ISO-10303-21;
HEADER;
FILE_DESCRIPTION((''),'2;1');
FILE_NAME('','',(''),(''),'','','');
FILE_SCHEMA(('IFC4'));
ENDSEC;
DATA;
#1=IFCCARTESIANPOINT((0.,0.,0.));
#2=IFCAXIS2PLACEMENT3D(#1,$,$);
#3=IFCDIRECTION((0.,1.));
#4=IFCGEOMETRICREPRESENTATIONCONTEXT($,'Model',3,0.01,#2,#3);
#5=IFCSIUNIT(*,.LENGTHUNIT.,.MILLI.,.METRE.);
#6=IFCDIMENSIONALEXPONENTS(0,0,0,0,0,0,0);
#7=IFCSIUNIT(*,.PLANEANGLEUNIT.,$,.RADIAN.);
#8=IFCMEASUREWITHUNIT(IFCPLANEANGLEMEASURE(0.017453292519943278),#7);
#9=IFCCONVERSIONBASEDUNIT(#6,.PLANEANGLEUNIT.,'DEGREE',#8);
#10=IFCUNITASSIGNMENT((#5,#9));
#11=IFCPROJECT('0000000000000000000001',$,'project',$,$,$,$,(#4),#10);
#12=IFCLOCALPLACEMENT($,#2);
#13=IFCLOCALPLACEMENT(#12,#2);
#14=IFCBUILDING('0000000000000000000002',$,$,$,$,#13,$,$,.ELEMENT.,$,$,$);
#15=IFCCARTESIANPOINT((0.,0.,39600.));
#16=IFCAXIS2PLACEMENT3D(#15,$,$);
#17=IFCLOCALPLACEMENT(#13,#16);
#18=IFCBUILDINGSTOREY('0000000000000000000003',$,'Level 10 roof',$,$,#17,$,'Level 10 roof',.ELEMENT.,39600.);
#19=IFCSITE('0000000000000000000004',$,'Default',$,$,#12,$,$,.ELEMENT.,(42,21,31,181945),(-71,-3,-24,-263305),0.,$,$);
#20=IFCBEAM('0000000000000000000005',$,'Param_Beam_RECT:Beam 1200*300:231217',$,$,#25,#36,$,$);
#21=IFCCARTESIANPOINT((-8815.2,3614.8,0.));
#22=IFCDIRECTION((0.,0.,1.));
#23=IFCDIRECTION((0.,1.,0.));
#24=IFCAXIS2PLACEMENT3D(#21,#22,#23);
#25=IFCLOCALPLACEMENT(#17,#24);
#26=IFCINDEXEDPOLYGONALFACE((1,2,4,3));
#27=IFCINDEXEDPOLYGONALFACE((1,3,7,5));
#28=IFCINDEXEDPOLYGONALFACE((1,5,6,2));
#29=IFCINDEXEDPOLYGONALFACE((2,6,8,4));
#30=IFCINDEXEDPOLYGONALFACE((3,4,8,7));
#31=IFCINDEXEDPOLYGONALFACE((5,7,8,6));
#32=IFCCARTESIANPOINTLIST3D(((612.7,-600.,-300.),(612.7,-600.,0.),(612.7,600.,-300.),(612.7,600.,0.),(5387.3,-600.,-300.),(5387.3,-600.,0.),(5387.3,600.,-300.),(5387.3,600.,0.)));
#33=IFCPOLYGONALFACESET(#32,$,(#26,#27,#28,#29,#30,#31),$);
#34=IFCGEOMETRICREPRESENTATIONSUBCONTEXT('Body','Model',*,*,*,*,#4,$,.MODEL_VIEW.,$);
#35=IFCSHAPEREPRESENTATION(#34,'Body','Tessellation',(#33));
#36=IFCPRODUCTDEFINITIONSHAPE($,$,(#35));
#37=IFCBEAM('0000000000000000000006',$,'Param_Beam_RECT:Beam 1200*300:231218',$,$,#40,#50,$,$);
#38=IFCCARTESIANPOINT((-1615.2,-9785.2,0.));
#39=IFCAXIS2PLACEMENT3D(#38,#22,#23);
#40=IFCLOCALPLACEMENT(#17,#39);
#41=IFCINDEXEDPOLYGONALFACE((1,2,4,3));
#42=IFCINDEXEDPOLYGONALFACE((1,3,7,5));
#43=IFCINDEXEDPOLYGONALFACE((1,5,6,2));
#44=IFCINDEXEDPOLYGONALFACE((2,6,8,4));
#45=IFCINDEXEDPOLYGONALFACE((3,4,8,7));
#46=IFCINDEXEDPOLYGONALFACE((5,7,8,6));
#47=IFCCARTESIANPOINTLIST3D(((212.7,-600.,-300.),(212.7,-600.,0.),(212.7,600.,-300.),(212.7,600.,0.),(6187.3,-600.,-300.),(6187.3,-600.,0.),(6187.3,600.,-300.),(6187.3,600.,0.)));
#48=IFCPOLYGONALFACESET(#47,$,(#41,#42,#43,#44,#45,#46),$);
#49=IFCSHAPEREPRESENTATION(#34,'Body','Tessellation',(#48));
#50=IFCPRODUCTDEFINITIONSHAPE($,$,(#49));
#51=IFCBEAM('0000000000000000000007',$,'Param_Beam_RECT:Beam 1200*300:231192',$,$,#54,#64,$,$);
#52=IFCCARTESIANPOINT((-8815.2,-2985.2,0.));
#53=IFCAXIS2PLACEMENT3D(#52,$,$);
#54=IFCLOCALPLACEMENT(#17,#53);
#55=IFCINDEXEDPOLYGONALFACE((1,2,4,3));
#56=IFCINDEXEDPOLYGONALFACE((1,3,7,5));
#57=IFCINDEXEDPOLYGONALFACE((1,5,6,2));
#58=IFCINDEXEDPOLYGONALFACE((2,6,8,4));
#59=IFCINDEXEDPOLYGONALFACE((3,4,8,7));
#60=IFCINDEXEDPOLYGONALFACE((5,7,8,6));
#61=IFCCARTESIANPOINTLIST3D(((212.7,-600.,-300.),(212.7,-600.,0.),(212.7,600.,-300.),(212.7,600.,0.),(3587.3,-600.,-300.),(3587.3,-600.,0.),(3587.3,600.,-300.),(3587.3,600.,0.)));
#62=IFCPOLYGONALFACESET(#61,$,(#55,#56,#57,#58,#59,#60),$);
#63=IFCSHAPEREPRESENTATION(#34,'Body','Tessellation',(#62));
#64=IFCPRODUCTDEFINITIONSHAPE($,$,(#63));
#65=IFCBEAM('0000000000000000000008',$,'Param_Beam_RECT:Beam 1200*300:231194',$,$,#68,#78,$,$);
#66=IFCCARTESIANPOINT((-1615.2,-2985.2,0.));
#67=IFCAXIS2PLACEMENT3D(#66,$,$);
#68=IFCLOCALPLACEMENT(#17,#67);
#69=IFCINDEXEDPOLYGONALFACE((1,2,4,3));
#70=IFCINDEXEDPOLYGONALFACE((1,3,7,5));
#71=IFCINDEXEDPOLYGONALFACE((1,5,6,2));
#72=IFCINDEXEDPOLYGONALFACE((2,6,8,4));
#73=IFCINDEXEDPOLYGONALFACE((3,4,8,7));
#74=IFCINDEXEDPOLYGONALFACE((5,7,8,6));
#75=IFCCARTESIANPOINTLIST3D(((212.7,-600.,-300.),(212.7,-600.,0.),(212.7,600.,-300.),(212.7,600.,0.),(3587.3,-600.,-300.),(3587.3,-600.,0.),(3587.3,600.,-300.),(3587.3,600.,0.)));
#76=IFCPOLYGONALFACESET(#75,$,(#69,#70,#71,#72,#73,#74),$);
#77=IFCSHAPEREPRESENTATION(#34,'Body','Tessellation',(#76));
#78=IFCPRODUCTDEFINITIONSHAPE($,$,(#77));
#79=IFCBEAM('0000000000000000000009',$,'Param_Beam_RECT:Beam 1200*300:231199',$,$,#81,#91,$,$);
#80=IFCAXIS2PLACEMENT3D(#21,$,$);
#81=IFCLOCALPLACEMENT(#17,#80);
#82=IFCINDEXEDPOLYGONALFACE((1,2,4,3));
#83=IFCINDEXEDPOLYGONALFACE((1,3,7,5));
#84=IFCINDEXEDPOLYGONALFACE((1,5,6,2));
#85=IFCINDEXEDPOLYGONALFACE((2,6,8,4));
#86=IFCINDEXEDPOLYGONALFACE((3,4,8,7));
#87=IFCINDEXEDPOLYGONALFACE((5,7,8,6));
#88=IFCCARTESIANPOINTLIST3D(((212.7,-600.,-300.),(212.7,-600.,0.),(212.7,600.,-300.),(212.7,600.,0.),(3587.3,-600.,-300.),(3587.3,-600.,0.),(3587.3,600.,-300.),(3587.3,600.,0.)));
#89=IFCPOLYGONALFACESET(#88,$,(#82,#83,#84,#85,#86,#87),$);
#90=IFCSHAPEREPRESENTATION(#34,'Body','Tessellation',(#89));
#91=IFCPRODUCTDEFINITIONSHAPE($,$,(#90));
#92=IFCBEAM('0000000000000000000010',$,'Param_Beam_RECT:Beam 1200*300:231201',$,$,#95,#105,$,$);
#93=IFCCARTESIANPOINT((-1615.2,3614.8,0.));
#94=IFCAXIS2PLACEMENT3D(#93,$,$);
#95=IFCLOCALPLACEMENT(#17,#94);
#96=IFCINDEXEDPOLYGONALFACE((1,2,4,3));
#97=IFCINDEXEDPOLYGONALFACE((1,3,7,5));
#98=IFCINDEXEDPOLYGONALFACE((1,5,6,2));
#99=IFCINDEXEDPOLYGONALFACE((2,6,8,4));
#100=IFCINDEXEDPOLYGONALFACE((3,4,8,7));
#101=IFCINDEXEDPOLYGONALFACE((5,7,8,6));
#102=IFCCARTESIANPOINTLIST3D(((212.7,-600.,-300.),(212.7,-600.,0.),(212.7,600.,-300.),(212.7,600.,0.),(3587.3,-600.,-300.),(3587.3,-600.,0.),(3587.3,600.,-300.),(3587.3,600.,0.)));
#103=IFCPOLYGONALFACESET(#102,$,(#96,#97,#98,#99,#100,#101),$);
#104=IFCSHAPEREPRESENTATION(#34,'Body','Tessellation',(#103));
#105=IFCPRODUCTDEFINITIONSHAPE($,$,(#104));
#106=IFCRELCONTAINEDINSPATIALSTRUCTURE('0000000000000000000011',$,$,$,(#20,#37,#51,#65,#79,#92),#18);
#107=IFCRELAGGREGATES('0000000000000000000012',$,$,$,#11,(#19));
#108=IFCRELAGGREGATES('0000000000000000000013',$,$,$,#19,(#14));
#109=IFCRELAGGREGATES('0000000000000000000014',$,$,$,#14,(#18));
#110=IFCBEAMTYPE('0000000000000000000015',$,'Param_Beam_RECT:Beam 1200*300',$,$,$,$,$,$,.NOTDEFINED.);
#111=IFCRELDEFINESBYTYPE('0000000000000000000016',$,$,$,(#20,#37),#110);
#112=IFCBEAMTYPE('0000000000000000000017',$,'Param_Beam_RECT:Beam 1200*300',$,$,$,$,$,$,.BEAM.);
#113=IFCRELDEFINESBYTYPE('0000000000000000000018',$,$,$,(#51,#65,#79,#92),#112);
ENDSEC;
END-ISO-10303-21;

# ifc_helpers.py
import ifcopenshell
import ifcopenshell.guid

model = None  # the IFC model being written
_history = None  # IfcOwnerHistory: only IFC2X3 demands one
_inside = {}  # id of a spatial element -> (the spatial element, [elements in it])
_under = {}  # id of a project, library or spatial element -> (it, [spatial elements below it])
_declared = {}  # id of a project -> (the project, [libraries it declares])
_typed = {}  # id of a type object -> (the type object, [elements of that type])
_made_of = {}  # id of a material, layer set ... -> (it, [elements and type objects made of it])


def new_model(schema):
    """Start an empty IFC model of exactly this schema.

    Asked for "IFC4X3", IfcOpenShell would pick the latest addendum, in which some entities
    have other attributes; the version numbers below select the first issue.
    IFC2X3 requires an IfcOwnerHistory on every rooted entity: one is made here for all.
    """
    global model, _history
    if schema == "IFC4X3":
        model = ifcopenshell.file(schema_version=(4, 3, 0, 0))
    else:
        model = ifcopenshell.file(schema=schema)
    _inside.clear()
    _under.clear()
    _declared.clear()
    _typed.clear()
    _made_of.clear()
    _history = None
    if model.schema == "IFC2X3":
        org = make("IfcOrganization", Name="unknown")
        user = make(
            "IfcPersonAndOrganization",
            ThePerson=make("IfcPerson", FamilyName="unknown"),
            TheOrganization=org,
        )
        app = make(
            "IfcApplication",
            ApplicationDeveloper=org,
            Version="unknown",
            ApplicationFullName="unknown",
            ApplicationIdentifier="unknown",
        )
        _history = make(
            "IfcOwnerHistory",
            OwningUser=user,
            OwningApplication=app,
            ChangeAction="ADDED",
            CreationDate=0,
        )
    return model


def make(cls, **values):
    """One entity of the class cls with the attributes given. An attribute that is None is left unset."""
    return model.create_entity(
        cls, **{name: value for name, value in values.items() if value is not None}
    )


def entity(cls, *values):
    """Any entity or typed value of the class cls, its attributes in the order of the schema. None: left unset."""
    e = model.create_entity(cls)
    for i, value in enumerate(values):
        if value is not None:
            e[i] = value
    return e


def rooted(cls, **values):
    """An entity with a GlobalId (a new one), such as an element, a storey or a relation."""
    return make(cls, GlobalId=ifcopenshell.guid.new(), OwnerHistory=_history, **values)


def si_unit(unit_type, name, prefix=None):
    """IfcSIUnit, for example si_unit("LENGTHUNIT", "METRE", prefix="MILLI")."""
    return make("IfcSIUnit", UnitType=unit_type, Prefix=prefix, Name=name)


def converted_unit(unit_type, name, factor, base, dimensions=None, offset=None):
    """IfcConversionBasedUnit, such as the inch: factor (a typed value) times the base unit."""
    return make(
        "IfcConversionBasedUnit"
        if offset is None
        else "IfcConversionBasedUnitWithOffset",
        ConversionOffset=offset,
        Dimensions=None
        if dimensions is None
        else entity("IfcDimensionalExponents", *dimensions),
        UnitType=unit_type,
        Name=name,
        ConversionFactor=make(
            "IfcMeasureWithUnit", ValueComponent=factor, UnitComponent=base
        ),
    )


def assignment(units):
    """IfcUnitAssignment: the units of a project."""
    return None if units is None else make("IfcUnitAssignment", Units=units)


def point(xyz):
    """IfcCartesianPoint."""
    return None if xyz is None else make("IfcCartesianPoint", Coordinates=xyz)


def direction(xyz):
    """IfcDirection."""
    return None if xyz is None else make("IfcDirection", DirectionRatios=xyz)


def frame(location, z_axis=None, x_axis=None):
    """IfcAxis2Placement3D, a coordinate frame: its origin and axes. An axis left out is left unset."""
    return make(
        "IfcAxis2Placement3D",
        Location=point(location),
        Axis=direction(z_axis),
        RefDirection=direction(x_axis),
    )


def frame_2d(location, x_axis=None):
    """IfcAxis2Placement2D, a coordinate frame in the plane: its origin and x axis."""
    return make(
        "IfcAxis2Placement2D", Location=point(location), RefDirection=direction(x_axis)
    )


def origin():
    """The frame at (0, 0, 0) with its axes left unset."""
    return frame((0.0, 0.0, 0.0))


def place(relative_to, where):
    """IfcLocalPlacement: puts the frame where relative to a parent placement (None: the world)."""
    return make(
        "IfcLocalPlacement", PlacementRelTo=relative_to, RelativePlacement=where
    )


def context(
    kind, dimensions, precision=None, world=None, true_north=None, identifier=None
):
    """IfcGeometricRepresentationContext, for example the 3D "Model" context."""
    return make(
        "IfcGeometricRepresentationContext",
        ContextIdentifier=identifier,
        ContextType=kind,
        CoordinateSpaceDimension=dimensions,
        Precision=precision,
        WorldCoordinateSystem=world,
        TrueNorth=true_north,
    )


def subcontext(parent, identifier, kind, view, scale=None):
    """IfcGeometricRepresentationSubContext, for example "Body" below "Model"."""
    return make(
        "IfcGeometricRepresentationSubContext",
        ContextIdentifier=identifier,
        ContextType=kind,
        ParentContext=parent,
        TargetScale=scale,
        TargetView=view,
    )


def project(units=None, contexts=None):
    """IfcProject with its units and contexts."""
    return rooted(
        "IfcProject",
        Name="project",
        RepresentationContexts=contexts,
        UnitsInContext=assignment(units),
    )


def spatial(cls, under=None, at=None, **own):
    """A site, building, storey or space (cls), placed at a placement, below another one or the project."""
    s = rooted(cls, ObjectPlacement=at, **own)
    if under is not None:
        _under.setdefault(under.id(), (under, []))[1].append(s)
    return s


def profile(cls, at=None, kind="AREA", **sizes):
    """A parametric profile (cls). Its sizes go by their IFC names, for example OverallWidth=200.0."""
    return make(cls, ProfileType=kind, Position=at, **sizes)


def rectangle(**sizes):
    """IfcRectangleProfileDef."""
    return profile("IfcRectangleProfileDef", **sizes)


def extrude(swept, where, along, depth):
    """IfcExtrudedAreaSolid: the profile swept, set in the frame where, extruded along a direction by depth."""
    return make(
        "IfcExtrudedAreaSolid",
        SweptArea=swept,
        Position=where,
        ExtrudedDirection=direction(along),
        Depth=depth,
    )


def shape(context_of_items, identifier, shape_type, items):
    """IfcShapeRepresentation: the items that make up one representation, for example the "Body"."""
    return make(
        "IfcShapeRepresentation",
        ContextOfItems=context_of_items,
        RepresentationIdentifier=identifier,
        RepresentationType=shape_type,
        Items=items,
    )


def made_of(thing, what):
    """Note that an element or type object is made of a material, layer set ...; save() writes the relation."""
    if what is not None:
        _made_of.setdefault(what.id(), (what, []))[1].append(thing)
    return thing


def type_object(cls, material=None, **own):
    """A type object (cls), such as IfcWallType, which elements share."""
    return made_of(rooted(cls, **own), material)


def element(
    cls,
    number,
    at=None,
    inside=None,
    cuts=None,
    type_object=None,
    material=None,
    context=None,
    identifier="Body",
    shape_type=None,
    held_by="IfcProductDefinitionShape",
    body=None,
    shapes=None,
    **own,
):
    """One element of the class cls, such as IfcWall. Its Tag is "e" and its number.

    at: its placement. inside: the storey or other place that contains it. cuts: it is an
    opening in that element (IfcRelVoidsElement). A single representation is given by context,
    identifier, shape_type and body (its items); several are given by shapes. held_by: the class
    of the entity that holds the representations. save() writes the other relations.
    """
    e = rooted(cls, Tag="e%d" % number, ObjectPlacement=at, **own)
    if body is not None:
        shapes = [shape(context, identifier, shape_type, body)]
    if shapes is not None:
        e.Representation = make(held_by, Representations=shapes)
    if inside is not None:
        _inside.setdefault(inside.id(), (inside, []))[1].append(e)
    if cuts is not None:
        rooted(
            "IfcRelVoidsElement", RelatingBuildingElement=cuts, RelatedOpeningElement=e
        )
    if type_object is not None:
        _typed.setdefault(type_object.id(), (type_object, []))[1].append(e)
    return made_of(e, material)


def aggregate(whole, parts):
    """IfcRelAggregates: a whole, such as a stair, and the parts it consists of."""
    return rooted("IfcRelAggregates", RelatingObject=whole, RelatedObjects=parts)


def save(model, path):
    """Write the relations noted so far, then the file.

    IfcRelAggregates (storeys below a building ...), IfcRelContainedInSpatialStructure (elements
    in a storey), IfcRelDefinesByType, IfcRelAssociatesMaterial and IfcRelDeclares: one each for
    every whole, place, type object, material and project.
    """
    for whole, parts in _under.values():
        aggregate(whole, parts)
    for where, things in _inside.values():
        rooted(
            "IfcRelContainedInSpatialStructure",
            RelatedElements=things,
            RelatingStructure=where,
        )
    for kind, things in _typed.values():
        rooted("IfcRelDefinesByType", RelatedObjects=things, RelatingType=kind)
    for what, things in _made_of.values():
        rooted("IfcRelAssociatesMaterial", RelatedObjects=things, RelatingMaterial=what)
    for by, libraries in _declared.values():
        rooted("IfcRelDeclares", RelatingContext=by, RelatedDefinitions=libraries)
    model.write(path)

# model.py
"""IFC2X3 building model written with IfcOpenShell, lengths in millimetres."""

from ifc_helpers import new_model, entity, si_unit, converted_unit, direction, frame, frame_2d, origin, place, context, subcontext, project, spatial, rectangle, extrude, type_object, element, save


model = new_model("IFC2X3")

# Units and contexts
model_context = context("Model", 3, precision=0.01, world=origin(), true_north=direction((0.0, 1.0)))
body_context = subcontext(model_context, "Body", "Model", "MODEL_VIEW")
ifc_project = project(units=[si_unit("LENGTHUNIT", "METRE", prefix="MILLI"), converted_unit("PLANEANGLEUNIT", "DEGREE", entity("IfcPlaneAngleMeasure", 0.017453292519943278), si_unit("PLANEANGLEUNIT", "RADIAN"), dimensions=[0, 0, 0, 0, 0, 0, 0])], contexts=[model_context])

# Site, building, storey
site_placement = place(None, origin())
site = spatial("IfcSite", under=ifc_project, at=site_placement, Name="Default", CompositionType="ELEMENT", RefLatitude=(42, 21, 31, 181945), RefLongitude=(-71, -3, -24, -263305), RefElevation=0.0)
building_placement = place(site_placement, origin())
building = spatial("IfcBuilding", under=site, at=building_placement, CompositionType="ELEMENT")
storey_placement = place(building_placement, frame((0.0, 0.0, 39600.0)))
storey = spatial("IfcBuildingStorey", under=building, at=storey_placement, Name="Level 10 roof", LongName="Level 10 roof", CompositionType="ELEMENT", Elevation=39600.0)

# Beams
beam_type_1 = type_object("IfcBeamType", Name="Param_Beam_RECT:Beam 1200*300", PredefinedType="NOTDEFINED")
beam_1_placement = place(storey_placement, frame((-8815.2, 3614.8, 0.0), z_axis=(0.0, 0.0, 1.0), x_axis=(0.0, 1.0, 0.0)))
element("IfcBeam", 1, at=beam_1_placement, inside=storey, type_object=beam_type_1, Name="Param_Beam_RECT:Beam 1200*300:231217", context=body_context, shape_type="SweptSolid", body=[
    extrude(rectangle(XDim=300.0, YDim=1200.0, at=frame_2d((0.0, 0.0), x_axis=(1.0, 0.0))), frame((612.7, 0.0, -150.0), z_axis=(1.0, 0.0, 0.0), x_axis=(0.0, 0.0, -1.0)), (0.0, 0.0, 1.0), 4774.6),
])
beam_2_placement = place(storey_placement, frame((-1615.2, -9785.2, 0.0), z_axis=(0.0, 0.0, 1.0), x_axis=(0.0, 1.0, 0.0)))
element("IfcBeam", 2, at=beam_2_placement, inside=storey, type_object=beam_type_1, Name="Param_Beam_RECT:Beam 1200*300:231218", context=body_context, shape_type="SweptSolid", body=[
    extrude(rectangle(XDim=300.0, YDim=1200.0, at=frame_2d((0.0, 0.0), x_axis=(1.0, 0.0))), frame((212.7, 0.0, -150.0), z_axis=(1.0, 0.0, 0.0), x_axis=(0.0, 0.0, -1.0)), (0.0, 0.0, 1.0), 5974.6),
])
beam_type_2 = type_object("IfcBeamType", Name="Param_Beam_RECT:Beam 1200*300", PredefinedType="BEAM")
beam_3_placement = place(storey_placement, frame((-8815.2, -2985.2, 0.0)))
element("IfcBeam", 3, at=beam_3_placement, inside=storey, type_object=beam_type_2, Name="Param_Beam_RECT:Beam 1200*300:231192", context=body_context, shape_type="SweptSolid", body=[
    extrude(rectangle(XDim=300.0, YDim=1200.0, at=frame_2d((0.0, 0.0), x_axis=(1.0, 0.0))), frame((212.7, 0.0, -150.0), z_axis=(1.0, 0.0, 0.0), x_axis=(0.0, 0.0, -1.0)), (0.0, 0.0, 1.0), 3374.6),
])
beam_4_placement = place(storey_placement, frame((-1615.2, -2985.2, 0.0)))
element("IfcBeam", 4, at=beam_4_placement, inside=storey, type_object=beam_type_2, Name="Param_Beam_RECT:Beam 1200*300:231194", context=body_context, shape_type="SweptSolid", body=[
    extrude(rectangle(XDim=300.0, YDim=1200.0, at=frame_2d((0.0, 0.0), x_axis=(1.0, 0.0))), frame((212.7, 0.0, -150.0), z_axis=(1.0, 0.0, 0.0), x_axis=(0.0, 0.0, -1.0)), (0.0, 0.0, 1.0), 3374.6),
])
beam_5_placement = place(storey_placement, frame((-8815.2, 3614.8, 0.0)))
element("IfcBeam", 5, at=beam_5_placement, inside=storey, type_object=beam_type_2, Name="Param_Beam_RECT:Beam 1200*300:231199", context=body_context, shape_type="SweptSolid", body=[
    extrude(rectangle(XDim=300.0, YDim=1200.0, at=frame_2d((0.0, 0.0), x_axis=(1.0, 0.0))), frame((212.7, 0.0, -150.0), z_axis=(1.0, 0.0, 0.0), x_axis=(0.0, 0.0, -1.0)), (0.0, 0.0, 1.0), 3374.6),
])
beam_6_placement = place(storey_placement, frame((-1615.2, 3614.8, 0.0)))
element("IfcBeam", 6, at=beam_6_placement, inside=storey, type_object=beam_type_2, Name="Param_Beam_RECT:Beam 1200*300:231201", context=body_context, shape_type="SweptSolid", body=[
    extrude(rectangle(XDim=300.0, YDim=1200.0, at=frame_2d((0.0, 0.0), x_axis=(1.0, 0.0))), frame((212.7, 0.0, -150.0), z_axis=(1.0, 0.0, 0.0), x_axis=(0.0, 0.0, -1.0)), (0.0, 0.0, 1.0), 3374.6),
])

save(model, "model.ifc")
